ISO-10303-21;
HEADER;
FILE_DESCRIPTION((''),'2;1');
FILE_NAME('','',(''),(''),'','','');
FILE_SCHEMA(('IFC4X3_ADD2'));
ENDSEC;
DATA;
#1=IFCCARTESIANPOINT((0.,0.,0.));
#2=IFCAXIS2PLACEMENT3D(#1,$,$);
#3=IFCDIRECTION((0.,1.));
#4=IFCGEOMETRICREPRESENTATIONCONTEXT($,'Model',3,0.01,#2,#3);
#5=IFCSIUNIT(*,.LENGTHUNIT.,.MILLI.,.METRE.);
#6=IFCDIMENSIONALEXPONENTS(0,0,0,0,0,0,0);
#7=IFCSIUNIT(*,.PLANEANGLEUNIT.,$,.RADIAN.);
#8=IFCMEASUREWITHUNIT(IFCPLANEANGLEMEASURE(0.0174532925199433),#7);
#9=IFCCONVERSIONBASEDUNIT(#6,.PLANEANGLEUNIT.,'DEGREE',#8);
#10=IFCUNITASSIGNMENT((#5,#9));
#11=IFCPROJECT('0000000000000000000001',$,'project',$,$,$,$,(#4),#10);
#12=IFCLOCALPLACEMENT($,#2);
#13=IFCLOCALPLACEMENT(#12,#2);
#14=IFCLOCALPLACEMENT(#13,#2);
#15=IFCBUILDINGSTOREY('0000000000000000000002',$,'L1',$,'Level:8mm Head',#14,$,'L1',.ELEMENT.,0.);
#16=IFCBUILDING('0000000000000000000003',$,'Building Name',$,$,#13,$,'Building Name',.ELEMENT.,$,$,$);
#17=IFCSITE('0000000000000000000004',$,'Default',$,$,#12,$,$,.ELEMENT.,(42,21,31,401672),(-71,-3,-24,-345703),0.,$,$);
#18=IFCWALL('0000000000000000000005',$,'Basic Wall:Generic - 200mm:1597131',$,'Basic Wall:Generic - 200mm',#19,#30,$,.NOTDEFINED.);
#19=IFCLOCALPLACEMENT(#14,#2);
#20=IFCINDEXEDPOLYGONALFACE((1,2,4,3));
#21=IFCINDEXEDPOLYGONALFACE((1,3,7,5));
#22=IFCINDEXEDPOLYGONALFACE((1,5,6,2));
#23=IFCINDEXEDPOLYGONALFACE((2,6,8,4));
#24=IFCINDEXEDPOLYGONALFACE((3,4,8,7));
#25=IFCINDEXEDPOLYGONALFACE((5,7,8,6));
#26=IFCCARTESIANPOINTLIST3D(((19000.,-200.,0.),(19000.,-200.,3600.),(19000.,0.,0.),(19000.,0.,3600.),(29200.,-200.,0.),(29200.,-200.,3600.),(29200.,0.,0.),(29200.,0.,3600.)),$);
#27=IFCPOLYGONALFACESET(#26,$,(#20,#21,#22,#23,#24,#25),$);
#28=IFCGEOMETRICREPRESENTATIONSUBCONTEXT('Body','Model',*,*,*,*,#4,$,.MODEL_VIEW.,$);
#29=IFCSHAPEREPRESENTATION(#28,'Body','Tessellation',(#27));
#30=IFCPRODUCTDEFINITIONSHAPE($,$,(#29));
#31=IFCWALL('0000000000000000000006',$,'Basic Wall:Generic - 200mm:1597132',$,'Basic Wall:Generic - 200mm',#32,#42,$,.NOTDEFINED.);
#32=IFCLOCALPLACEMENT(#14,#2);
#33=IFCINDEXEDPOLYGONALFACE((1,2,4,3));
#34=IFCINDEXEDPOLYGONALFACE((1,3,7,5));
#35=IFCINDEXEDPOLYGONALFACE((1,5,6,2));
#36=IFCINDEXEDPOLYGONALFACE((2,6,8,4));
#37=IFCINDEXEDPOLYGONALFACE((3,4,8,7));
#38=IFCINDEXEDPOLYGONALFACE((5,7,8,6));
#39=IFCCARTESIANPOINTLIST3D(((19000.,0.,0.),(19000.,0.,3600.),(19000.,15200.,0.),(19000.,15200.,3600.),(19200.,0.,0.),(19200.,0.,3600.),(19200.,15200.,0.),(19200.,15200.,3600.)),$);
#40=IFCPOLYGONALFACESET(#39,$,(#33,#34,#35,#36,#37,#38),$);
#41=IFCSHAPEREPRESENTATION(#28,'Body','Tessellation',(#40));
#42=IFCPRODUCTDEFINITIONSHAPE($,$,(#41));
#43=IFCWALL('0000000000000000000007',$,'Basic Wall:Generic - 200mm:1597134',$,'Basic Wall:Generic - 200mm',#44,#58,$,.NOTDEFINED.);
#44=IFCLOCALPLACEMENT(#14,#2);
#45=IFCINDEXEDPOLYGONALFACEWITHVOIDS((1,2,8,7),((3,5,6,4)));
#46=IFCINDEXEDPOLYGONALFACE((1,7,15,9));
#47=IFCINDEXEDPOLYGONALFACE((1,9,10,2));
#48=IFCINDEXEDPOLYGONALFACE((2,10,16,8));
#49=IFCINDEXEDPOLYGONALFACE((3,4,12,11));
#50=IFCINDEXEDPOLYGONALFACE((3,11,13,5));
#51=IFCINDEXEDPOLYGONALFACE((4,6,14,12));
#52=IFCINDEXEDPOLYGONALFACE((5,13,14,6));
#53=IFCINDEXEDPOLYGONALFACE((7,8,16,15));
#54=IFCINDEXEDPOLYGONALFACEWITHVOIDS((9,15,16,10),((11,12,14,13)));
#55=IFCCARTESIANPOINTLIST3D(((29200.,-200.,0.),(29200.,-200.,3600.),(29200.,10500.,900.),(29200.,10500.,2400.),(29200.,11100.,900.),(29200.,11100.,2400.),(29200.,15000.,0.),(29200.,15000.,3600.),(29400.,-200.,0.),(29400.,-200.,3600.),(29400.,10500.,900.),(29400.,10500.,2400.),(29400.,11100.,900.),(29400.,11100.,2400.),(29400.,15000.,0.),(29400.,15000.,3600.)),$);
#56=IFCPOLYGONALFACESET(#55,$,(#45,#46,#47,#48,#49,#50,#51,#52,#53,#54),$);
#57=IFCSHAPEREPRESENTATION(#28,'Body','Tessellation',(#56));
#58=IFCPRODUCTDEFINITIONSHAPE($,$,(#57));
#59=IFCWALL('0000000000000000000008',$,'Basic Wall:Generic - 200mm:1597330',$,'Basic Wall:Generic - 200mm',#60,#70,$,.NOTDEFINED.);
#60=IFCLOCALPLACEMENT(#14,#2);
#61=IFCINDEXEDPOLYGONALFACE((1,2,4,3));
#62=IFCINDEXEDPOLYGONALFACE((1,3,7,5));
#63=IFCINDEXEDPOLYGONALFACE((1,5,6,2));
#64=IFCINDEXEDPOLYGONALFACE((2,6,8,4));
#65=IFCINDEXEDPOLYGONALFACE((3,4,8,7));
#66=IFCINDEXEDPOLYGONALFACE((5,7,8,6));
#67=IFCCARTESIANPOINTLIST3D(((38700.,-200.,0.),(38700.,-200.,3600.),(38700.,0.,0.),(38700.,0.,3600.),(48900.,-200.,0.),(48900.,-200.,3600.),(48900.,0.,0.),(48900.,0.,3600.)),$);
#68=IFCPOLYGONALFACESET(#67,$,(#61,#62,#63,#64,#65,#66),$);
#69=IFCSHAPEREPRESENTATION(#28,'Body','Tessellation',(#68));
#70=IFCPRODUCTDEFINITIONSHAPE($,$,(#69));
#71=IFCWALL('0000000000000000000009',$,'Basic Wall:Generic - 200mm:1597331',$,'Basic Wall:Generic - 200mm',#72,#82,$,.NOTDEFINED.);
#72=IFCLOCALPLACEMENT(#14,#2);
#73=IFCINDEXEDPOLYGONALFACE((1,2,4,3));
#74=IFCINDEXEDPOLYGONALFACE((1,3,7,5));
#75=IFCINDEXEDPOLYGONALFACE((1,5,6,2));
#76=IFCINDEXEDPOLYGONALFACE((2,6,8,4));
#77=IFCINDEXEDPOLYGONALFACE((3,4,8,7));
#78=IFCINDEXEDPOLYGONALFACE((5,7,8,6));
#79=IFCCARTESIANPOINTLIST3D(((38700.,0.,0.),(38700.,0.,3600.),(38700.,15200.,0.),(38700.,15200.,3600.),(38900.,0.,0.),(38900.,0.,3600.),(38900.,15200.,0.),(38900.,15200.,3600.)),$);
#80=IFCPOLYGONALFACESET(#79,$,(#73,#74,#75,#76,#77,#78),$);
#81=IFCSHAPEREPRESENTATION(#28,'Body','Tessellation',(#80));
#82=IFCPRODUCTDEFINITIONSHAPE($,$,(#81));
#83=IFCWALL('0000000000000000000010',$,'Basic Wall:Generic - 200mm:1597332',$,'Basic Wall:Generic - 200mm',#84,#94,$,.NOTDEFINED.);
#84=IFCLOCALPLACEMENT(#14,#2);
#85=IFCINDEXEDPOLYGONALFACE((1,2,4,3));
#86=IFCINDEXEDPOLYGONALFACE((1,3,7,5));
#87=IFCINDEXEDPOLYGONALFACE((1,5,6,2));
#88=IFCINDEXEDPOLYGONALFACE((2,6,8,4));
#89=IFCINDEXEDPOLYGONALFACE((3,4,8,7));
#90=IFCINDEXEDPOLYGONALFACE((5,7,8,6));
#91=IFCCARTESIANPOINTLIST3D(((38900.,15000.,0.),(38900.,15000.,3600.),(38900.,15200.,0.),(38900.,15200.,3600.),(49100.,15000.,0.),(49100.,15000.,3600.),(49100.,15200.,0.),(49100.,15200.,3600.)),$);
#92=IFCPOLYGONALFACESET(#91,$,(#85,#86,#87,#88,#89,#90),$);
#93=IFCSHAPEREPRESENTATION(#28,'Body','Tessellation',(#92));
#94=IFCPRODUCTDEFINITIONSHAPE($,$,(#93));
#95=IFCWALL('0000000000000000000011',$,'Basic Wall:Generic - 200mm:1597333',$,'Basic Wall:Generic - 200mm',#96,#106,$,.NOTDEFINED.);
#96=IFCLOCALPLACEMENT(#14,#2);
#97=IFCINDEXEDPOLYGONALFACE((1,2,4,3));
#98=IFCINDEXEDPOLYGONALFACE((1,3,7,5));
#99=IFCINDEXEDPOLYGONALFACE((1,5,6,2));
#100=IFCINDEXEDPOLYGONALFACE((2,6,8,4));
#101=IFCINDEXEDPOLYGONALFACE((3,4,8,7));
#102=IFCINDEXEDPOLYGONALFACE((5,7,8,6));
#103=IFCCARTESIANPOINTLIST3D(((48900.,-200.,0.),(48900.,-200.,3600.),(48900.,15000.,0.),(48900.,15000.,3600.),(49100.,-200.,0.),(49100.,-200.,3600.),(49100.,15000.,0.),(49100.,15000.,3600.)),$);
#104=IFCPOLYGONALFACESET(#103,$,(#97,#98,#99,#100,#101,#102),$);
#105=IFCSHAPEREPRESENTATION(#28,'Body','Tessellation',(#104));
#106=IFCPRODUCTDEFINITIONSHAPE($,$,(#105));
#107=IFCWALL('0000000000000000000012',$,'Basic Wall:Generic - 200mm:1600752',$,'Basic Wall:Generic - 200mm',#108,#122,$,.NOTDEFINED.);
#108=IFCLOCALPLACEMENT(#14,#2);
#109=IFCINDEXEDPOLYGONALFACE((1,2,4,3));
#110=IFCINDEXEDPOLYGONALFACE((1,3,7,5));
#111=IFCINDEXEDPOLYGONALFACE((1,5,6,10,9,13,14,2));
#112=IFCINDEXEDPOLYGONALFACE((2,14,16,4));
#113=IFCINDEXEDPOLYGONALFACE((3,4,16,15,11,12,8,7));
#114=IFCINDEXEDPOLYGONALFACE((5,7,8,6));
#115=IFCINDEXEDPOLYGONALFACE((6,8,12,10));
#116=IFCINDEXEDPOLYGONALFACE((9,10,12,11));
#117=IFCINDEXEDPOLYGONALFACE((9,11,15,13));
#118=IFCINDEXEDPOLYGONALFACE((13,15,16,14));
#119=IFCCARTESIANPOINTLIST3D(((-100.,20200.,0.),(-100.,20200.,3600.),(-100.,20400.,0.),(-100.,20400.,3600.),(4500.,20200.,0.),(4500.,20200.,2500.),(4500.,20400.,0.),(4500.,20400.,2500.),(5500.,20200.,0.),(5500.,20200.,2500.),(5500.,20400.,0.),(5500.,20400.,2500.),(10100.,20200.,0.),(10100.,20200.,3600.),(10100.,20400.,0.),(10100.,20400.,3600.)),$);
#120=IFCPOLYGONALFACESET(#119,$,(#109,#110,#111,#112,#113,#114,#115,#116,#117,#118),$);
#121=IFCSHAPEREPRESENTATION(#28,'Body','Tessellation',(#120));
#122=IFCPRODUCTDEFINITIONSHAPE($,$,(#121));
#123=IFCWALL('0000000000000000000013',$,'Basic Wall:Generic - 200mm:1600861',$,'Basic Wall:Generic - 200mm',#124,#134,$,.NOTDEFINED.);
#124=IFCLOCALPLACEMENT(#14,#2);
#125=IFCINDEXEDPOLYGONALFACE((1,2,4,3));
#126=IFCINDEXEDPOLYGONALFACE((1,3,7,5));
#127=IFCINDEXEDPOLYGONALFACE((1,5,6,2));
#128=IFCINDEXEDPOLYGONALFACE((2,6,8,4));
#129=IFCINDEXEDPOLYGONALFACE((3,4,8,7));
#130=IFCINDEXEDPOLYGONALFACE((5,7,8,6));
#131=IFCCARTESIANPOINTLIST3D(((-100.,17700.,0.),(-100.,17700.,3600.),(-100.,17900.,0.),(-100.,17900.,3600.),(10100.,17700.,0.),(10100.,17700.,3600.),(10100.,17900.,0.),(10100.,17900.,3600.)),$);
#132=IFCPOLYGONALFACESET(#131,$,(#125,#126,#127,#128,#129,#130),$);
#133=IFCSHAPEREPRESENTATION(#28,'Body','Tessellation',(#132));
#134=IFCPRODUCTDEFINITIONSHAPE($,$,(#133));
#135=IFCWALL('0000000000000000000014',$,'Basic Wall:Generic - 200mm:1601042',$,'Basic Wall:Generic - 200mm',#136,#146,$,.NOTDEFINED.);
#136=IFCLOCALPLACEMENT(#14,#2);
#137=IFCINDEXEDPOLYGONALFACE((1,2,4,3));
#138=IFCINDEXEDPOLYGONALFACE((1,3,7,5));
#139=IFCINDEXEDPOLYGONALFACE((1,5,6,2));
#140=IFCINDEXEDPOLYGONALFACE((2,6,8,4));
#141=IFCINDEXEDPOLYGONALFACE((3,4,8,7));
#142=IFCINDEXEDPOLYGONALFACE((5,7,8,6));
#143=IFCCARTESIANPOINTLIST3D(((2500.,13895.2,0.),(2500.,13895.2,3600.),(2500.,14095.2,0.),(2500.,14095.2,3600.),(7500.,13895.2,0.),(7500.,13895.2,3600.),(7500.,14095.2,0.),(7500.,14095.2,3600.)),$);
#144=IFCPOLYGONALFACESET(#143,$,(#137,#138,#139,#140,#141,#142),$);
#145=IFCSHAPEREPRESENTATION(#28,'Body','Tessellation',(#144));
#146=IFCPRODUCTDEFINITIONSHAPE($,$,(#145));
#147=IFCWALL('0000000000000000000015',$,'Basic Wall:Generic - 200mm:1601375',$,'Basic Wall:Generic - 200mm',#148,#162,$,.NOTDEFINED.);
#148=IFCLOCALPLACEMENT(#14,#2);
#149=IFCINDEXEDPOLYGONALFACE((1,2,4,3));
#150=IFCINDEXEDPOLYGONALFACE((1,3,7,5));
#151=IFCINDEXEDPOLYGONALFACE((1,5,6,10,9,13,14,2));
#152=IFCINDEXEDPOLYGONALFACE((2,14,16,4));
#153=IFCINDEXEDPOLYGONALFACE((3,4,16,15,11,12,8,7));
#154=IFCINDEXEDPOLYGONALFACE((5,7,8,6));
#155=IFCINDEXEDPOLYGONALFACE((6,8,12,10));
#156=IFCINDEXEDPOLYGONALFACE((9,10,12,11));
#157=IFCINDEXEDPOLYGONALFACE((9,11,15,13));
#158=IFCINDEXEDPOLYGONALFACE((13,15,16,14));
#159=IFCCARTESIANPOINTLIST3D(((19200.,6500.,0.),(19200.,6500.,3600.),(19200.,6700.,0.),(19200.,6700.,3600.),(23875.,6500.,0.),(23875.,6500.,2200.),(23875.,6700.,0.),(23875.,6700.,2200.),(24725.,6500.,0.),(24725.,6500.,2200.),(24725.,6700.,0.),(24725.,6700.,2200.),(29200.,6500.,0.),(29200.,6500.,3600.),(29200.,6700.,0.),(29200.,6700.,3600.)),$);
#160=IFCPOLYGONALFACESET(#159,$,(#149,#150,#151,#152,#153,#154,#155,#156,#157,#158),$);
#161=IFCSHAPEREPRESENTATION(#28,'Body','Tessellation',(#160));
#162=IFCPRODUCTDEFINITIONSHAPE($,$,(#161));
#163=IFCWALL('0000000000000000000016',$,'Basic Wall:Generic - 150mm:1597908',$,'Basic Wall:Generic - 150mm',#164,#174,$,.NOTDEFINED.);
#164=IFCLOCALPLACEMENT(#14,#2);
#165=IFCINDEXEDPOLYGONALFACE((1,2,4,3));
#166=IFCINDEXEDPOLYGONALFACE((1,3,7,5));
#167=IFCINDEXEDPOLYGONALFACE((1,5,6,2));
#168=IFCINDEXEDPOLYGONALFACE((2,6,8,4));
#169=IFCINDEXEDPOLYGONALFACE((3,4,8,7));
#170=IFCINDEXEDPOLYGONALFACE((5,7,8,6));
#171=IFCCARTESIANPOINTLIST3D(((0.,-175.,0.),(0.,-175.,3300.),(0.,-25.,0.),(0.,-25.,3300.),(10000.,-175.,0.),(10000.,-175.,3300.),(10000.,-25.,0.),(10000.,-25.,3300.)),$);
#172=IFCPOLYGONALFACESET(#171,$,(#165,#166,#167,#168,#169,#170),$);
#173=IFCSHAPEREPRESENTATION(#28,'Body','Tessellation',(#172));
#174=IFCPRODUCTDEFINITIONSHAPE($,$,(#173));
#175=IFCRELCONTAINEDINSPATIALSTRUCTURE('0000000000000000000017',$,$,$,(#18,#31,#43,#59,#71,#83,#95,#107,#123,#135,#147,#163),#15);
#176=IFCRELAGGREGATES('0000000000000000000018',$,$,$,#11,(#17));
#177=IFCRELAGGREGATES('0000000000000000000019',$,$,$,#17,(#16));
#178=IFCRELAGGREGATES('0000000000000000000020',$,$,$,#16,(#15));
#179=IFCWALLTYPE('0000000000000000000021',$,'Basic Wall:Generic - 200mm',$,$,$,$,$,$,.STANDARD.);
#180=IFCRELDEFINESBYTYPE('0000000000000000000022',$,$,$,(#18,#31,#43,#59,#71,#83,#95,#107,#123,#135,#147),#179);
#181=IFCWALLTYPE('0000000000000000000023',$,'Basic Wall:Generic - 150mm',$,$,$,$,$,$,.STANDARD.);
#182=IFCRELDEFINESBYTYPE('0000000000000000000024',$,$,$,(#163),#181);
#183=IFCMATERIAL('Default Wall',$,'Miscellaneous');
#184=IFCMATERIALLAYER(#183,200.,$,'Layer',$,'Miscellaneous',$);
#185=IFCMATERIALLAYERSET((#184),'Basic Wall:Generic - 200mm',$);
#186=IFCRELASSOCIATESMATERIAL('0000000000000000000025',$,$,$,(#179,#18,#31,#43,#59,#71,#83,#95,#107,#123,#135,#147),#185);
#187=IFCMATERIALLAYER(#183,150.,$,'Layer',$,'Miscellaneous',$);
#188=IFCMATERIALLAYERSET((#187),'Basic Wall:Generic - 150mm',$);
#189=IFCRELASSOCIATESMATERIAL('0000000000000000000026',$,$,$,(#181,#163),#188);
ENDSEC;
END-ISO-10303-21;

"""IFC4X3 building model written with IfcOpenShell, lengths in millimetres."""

from ifc_helpers import new_model, entity, si_unit, converted_unit, direction, frame, frame_2d, origin, origin_2d_with_axis, place, context, subcontext, project, spatial, rectangle, extrude, material, layer, layer_set, type_object, element, save


model = new_model("IFC4X3")

# Units and contexts
model_context = context("Model", 3, precision=0.01, world=origin(), true_north=direction((0.0, 1.0)))
body_context = subcontext(model_context, "Body", "Model", "MODEL_VIEW")
ifc_project = project(units=[si_unit("LENGTHUNIT", "METRE", prefix="MILLI"), converted_unit("PLANEANGLEUNIT", "DEGREE", entity("IfcPlaneAngleMeasure", 0.0174532925199433), si_unit("PLANEANGLEUNIT", "RADIAN"), dimensions=[0, 0, 0, 0, 0, 0, 0])], contexts=[model_context])

# Site, building, storey
site_placement = place(None, origin())
site = spatial("IfcSite", under=ifc_project, at=site_placement, Name="Default", CompositionType="ELEMENT", RefLatitude=(42, 21, 31, 401672), RefLongitude=(-71, -3, -24, -345703), RefElevation=0.0)
building_placement = place(site_placement, origin())
building = spatial("IfcBuilding", under=site, at=building_placement, Name="Building Name", LongName="Building Name", CompositionType="ELEMENT")
storey_placement = place(building_placement, origin())
storey = spatial("IfcBuildingStorey", under=building, at=storey_placement, Name="L1", ObjectType="Level:8mm Head", LongName="L1", CompositionType="ELEMENT", Elevation=0.0)

# Walls
ifc_material_1 = material(Name="Default Wall", Category="Miscellaneous")
ifc_layer_1 = layer(ifc_material_1, 200.0, Name="Layer", Category="Miscellaneous")
ifc_layer_set_1 = layer_set([ifc_layer_1], Name="Basic Wall:Generic - 200mm")
wall_type_1 = type_object("IfcWallType", Name="Basic Wall:Generic - 200mm", PredefinedType="STANDARD", material=ifc_layer_set_1)
wall_1_placement = place(storey_placement, frame((19000.0, -100.0, 0.0)))
element("IfcWall", 1, at=wall_1_placement, inside=storey, type_object=wall_type_1, material=ifc_layer_set_1, Name="Basic Wall:Generic - 200mm:1597131", ObjectType="Basic Wall:Generic - 200mm", PredefinedType="NOTDEFINED", context=body_context, shape_type="SweptSolid", body=[
    extrude(rectangle(XDim=10200.0, YDim=200.0, at=frame_2d((5100.0, 0.0), x_axis=(-1.0, 0.0))), origin(), (0.0, 0.0, 1.0), 3600.0),
])
wall_2_placement = place(storey_placement, frame((19100.0, 15200.0, 0.0), z_axis=(0.0, 0.0, 1.0), x_axis=(0.0, -1.0, 0.0)))
element("IfcWall", 2, at=wall_2_placement, inside=storey, type_object=wall_type_1, material=ifc_layer_set_1, Name="Basic Wall:Generic - 200mm:1597132", ObjectType="Basic Wall:Generic - 200mm", PredefinedType="NOTDEFINED", context=body_context, shape_type="SweptSolid", body=[
    extrude(rectangle(XDim=15200.0, YDim=200.0, at=frame_2d((7600.0, 0.0), x_axis=(-1.0, 0.0))), origin(), (0.0, 0.0, 1.0), 3600.0),
])

# Wall, opening
wall_3_placement = place(storey_placement, frame((29300.0, -200.0, 0.0), z_axis=(0.0, 0.0, 1.0), x_axis=(0.0, 1.0, 0.0)))
wall_3 = element("IfcWall", 3, at=wall_3_placement, inside=storey, type_object=wall_type_1, material=ifc_layer_set_1, Name="Basic Wall:Generic - 200mm:1597134", ObjectType="Basic Wall:Generic - 200mm", PredefinedType="NOTDEFINED", context=body_context, shape_type="SweptSolid", body=[
    extrude(rectangle(XDim=15200.0, YDim=200.0, at=frame_2d((7600.0, 0.0), x_axis=(-1.0, 0.0))), origin(), (0.0, 0.0, 1.0), 3600.0),
])
opening_1_placement = place(wall_3_placement, frame((11300.0, 100.0, 900.0)))
element("IfcOpeningElement", 4, at=opening_1_placement, cuts=wall_3, PredefinedType="OPENING", context=body_context, shape_type="SweptSolid", body=[
    extrude(rectangle(XDim=1500.0, YDim=600.0, at=frame_2d((750.0, 300.0), x_axis=(-1.0, 0.0))), frame((0.0, 0.0, 0.0), z_axis=(0.0, -1.0, 0.0), x_axis=(0.0, 0.0, 1.0)), (0.0, 0.0, 1.0), 200.0),
])

# Walls
wall_4_placement = place(storey_placement, frame((38700.0, -100.0, 0.0)))
element("IfcWall", 5, at=wall_4_placement, inside=storey, type_object=wall_type_1, material=ifc_layer_set_1, Name="Basic Wall:Generic - 200mm:1597330", ObjectType="Basic Wall:Generic - 200mm", PredefinedType="NOTDEFINED", context=body_context, shape_type="SweptSolid", body=[
    extrude(rectangle(XDim=10200.0, YDim=200.0, at=frame_2d((5100.0, 0.0), x_axis=(-1.0, 0.0))), origin(), (0.0, 0.0, 1.0), 3600.0),
])
wall_5_placement = place(storey_placement, frame((38800.0, 15200.0, 0.0), z_axis=(0.0, 0.0, 1.0), x_axis=(0.0, -1.0, 0.0)))
element("IfcWall", 6, at=wall_5_placement, inside=storey, type_object=wall_type_1, material=ifc_layer_set_1, Name="Basic Wall:Generic - 200mm:1597331", ObjectType="Basic Wall:Generic - 200mm", PredefinedType="NOTDEFINED", context=body_context, shape_type="SweptSolid", body=[
    extrude(rectangle(XDim=15200.0, YDim=200.0, at=frame_2d((7600.0, 0.0), x_axis=(-1.0, 0.0))), origin(), (0.0, 0.0, 1.0), 3600.0),
])
wall_6_placement = place(storey_placement, frame((49100.0, 15100.0, 0.0), z_axis=(0.0, 0.0, 1.0), x_axis=(-1.0, 0.0, 0.0)))
element("IfcWall", 7, at=wall_6_placement, inside=storey, type_object=wall_type_1, material=ifc_layer_set_1, Name="Basic Wall:Generic - 200mm:1597332", ObjectType="Basic Wall:Generic - 200mm", PredefinedType="NOTDEFINED", context=body_context, shape_type="SweptSolid", body=[
    extrude(rectangle(XDim=10200.0, YDim=200.0, at=frame_2d((5100.0, 0.0), x_axis=(-1.0, 0.0))), origin(), (0.0, 0.0, 1.0), 3600.0),
])
wall_7_placement = place(storey_placement, frame((49000.0, -200.0, 0.0), z_axis=(0.0, 0.0, 1.0), x_axis=(0.0, 1.0, 0.0)))
element("IfcWall", 8, at=wall_7_placement, inside=storey, type_object=wall_type_1, material=ifc_layer_set_1, Name="Basic Wall:Generic - 200mm:1597333", ObjectType="Basic Wall:Generic - 200mm", PredefinedType="NOTDEFINED", context=body_context, shape_type="SweptSolid", body=[
    extrude(rectangle(XDim=15200.0, YDim=200.0, at=frame_2d((7600.0, 0.0), x_axis=(-1.0, 0.0))), origin(), (0.0, 0.0, 1.0), 3600.0),
])

# Wall, opening
wall_8_placement = place(storey_placement, frame((10100.0, 20300.0, 0.0), z_axis=(0.0, 0.0, 1.0), x_axis=(-1.0, 0.0, 0.0)))
wall_8 = element("IfcWall", 9, at=wall_8_placement, inside=storey, type_object=wall_type_1, material=ifc_layer_set_1, Name="Basic Wall:Generic - 200mm:1600752", ObjectType="Basic Wall:Generic - 200mm", PredefinedType="NOTDEFINED", context=body_context, shape_type="SweptSolid", body=[
    extrude(rectangle(XDim=10200.0, YDim=200.0, at=frame_2d((5100.0, 0.0), x_axis=(1.0, 0.0))), origin(), (0.0, 0.0, 1.0), 3600.0),
])
opening_2_placement = place(wall_8_placement, frame((5600.0, 100.0, 0.0)))
element("IfcOpeningElement", 10, at=opening_2_placement, cuts=wall_8, PredefinedType="OPENING", context=body_context, shape_type="SweptSolid", body=[
    extrude(rectangle(XDim=2500.0, YDim=1000.0, at=origin_2d_with_axis()), frame((-500.0, -200.0, 1250.0), z_axis=(0.0, 1.0, 0.0), x_axis=(0.0, 0.0, -1.0)), (0.0, 0.0, 1.0), 200.0),
])

# Walls
wall_9_placement = place(storey_placement, frame((10100.0, 17800.0, 0.0), z_axis=(0.0, 0.0, 1.0), x_axis=(-1.0, 0.0, 0.0)))
element("IfcWall", 11, at=wall_9_placement, inside=storey, type_object=wall_type_1, material=ifc_layer_set_1, Name="Basic Wall:Generic - 200mm:1600861", ObjectType="Basic Wall:Generic - 200mm", PredefinedType="NOTDEFINED", context=body_context, shape_type="SweptSolid", body=[
    extrude(rectangle(XDim=10200.0, YDim=200.0, at=frame_2d((5100.0, 0.0), x_axis=(-1.0, 0.0))), origin(), (0.0, 0.0, 1.0), 3600.0),
])
wall_10_placement = place(storey_placement, frame((7500.0, 13995.2, 0.0), z_axis=(0.0, 0.0, 1.0), x_axis=(-1.0, 0.0, 0.0)))
element("IfcWall", 12, at=wall_10_placement, inside=storey, type_object=wall_type_1, material=ifc_layer_set_1, Name="Basic Wall:Generic - 200mm:1601042", ObjectType="Basic Wall:Generic - 200mm", PredefinedType="NOTDEFINED", context=body_context, shape_type="SweptSolid", body=[
    extrude(rectangle(XDim=5000.0, YDim=200.0, at=frame_2d((2500.0, 0.0), x_axis=(-1.0, 0.0))), origin(), (0.0, 0.0, 1.0), 3600.0),
])

# Wall, opening
wall_11_placement = place(storey_placement, frame((29200.0, 6600.0, 0.0), z_axis=(0.0, 0.0, 1.0), x_axis=(-1.0, 0.0, 0.0)))
wall_11 = element("IfcWall", 13, at=wall_11_placement, inside=storey, type_object=wall_type_1, material=ifc_layer_set_1, Name="Basic Wall:Generic - 200mm:1601375", ObjectType="Basic Wall:Generic - 200mm", PredefinedType="NOTDEFINED", context=body_context, shape_type="SweptSolid", body=[
    extrude(rectangle(XDim=10000.0, YDim=200.0, at=frame_2d((5000.0, 0.0), x_axis=(1.0, 0.0))), origin(), (0.0, 0.0, 1.0), 3600.0),
])
opening_3_placement = place(wall_11_placement, frame((5325.0, 100.0, 0.0)))
element("IfcOpeningElement", 14, at=opening_3_placement, cuts=wall_11, PredefinedType="OPENING", context=body_context, shape_type="SweptSolid", body=[
    extrude(rectangle(XDim=2200.0, YDim=850.0, at=frame_2d((1100.0, 425.0), x_axis=(1.0, 0.0))), frame((0.0, 0.0, 0.0), z_axis=(0.0, -1.0, 0.0), x_axis=(0.0, 0.0, 1.0)), (0.0, 0.0, 1.0), 200.0),
])

# Wall
ifc_layer_2 = layer(ifc_material_1, 150.0, Name="Layer", Category="Miscellaneous")
ifc_layer_set_2 = layer_set([ifc_layer_2], Name="Basic Wall:Generic - 150mm")
wall_type_2 = type_object("IfcWallType", Name="Basic Wall:Generic - 150mm", PredefinedType="STANDARD", material=ifc_layer_set_2)
wall_12_placement = place(storey_placement, frame((0.0, -100.0, 0.0)))
element("IfcWall", 15, at=wall_12_placement, inside=storey, type_object=wall_type_2, material=ifc_layer_set_2, Name="Basic Wall:Generic - 150mm:1597908", ObjectType="Basic Wall:Generic - 150mm", PredefinedType="NOTDEFINED", context=body_context, shape_type="SweptSolid", body=[
    extrude(rectangle(XDim=10000.0, YDim=150.0, at=frame_2d((5000.0, 0.0), x_axis=(-1.0, 0.0))), origin(), (0.0, 0.0, 1.0), 3300.0),
])

save(model, "model.ifc")
